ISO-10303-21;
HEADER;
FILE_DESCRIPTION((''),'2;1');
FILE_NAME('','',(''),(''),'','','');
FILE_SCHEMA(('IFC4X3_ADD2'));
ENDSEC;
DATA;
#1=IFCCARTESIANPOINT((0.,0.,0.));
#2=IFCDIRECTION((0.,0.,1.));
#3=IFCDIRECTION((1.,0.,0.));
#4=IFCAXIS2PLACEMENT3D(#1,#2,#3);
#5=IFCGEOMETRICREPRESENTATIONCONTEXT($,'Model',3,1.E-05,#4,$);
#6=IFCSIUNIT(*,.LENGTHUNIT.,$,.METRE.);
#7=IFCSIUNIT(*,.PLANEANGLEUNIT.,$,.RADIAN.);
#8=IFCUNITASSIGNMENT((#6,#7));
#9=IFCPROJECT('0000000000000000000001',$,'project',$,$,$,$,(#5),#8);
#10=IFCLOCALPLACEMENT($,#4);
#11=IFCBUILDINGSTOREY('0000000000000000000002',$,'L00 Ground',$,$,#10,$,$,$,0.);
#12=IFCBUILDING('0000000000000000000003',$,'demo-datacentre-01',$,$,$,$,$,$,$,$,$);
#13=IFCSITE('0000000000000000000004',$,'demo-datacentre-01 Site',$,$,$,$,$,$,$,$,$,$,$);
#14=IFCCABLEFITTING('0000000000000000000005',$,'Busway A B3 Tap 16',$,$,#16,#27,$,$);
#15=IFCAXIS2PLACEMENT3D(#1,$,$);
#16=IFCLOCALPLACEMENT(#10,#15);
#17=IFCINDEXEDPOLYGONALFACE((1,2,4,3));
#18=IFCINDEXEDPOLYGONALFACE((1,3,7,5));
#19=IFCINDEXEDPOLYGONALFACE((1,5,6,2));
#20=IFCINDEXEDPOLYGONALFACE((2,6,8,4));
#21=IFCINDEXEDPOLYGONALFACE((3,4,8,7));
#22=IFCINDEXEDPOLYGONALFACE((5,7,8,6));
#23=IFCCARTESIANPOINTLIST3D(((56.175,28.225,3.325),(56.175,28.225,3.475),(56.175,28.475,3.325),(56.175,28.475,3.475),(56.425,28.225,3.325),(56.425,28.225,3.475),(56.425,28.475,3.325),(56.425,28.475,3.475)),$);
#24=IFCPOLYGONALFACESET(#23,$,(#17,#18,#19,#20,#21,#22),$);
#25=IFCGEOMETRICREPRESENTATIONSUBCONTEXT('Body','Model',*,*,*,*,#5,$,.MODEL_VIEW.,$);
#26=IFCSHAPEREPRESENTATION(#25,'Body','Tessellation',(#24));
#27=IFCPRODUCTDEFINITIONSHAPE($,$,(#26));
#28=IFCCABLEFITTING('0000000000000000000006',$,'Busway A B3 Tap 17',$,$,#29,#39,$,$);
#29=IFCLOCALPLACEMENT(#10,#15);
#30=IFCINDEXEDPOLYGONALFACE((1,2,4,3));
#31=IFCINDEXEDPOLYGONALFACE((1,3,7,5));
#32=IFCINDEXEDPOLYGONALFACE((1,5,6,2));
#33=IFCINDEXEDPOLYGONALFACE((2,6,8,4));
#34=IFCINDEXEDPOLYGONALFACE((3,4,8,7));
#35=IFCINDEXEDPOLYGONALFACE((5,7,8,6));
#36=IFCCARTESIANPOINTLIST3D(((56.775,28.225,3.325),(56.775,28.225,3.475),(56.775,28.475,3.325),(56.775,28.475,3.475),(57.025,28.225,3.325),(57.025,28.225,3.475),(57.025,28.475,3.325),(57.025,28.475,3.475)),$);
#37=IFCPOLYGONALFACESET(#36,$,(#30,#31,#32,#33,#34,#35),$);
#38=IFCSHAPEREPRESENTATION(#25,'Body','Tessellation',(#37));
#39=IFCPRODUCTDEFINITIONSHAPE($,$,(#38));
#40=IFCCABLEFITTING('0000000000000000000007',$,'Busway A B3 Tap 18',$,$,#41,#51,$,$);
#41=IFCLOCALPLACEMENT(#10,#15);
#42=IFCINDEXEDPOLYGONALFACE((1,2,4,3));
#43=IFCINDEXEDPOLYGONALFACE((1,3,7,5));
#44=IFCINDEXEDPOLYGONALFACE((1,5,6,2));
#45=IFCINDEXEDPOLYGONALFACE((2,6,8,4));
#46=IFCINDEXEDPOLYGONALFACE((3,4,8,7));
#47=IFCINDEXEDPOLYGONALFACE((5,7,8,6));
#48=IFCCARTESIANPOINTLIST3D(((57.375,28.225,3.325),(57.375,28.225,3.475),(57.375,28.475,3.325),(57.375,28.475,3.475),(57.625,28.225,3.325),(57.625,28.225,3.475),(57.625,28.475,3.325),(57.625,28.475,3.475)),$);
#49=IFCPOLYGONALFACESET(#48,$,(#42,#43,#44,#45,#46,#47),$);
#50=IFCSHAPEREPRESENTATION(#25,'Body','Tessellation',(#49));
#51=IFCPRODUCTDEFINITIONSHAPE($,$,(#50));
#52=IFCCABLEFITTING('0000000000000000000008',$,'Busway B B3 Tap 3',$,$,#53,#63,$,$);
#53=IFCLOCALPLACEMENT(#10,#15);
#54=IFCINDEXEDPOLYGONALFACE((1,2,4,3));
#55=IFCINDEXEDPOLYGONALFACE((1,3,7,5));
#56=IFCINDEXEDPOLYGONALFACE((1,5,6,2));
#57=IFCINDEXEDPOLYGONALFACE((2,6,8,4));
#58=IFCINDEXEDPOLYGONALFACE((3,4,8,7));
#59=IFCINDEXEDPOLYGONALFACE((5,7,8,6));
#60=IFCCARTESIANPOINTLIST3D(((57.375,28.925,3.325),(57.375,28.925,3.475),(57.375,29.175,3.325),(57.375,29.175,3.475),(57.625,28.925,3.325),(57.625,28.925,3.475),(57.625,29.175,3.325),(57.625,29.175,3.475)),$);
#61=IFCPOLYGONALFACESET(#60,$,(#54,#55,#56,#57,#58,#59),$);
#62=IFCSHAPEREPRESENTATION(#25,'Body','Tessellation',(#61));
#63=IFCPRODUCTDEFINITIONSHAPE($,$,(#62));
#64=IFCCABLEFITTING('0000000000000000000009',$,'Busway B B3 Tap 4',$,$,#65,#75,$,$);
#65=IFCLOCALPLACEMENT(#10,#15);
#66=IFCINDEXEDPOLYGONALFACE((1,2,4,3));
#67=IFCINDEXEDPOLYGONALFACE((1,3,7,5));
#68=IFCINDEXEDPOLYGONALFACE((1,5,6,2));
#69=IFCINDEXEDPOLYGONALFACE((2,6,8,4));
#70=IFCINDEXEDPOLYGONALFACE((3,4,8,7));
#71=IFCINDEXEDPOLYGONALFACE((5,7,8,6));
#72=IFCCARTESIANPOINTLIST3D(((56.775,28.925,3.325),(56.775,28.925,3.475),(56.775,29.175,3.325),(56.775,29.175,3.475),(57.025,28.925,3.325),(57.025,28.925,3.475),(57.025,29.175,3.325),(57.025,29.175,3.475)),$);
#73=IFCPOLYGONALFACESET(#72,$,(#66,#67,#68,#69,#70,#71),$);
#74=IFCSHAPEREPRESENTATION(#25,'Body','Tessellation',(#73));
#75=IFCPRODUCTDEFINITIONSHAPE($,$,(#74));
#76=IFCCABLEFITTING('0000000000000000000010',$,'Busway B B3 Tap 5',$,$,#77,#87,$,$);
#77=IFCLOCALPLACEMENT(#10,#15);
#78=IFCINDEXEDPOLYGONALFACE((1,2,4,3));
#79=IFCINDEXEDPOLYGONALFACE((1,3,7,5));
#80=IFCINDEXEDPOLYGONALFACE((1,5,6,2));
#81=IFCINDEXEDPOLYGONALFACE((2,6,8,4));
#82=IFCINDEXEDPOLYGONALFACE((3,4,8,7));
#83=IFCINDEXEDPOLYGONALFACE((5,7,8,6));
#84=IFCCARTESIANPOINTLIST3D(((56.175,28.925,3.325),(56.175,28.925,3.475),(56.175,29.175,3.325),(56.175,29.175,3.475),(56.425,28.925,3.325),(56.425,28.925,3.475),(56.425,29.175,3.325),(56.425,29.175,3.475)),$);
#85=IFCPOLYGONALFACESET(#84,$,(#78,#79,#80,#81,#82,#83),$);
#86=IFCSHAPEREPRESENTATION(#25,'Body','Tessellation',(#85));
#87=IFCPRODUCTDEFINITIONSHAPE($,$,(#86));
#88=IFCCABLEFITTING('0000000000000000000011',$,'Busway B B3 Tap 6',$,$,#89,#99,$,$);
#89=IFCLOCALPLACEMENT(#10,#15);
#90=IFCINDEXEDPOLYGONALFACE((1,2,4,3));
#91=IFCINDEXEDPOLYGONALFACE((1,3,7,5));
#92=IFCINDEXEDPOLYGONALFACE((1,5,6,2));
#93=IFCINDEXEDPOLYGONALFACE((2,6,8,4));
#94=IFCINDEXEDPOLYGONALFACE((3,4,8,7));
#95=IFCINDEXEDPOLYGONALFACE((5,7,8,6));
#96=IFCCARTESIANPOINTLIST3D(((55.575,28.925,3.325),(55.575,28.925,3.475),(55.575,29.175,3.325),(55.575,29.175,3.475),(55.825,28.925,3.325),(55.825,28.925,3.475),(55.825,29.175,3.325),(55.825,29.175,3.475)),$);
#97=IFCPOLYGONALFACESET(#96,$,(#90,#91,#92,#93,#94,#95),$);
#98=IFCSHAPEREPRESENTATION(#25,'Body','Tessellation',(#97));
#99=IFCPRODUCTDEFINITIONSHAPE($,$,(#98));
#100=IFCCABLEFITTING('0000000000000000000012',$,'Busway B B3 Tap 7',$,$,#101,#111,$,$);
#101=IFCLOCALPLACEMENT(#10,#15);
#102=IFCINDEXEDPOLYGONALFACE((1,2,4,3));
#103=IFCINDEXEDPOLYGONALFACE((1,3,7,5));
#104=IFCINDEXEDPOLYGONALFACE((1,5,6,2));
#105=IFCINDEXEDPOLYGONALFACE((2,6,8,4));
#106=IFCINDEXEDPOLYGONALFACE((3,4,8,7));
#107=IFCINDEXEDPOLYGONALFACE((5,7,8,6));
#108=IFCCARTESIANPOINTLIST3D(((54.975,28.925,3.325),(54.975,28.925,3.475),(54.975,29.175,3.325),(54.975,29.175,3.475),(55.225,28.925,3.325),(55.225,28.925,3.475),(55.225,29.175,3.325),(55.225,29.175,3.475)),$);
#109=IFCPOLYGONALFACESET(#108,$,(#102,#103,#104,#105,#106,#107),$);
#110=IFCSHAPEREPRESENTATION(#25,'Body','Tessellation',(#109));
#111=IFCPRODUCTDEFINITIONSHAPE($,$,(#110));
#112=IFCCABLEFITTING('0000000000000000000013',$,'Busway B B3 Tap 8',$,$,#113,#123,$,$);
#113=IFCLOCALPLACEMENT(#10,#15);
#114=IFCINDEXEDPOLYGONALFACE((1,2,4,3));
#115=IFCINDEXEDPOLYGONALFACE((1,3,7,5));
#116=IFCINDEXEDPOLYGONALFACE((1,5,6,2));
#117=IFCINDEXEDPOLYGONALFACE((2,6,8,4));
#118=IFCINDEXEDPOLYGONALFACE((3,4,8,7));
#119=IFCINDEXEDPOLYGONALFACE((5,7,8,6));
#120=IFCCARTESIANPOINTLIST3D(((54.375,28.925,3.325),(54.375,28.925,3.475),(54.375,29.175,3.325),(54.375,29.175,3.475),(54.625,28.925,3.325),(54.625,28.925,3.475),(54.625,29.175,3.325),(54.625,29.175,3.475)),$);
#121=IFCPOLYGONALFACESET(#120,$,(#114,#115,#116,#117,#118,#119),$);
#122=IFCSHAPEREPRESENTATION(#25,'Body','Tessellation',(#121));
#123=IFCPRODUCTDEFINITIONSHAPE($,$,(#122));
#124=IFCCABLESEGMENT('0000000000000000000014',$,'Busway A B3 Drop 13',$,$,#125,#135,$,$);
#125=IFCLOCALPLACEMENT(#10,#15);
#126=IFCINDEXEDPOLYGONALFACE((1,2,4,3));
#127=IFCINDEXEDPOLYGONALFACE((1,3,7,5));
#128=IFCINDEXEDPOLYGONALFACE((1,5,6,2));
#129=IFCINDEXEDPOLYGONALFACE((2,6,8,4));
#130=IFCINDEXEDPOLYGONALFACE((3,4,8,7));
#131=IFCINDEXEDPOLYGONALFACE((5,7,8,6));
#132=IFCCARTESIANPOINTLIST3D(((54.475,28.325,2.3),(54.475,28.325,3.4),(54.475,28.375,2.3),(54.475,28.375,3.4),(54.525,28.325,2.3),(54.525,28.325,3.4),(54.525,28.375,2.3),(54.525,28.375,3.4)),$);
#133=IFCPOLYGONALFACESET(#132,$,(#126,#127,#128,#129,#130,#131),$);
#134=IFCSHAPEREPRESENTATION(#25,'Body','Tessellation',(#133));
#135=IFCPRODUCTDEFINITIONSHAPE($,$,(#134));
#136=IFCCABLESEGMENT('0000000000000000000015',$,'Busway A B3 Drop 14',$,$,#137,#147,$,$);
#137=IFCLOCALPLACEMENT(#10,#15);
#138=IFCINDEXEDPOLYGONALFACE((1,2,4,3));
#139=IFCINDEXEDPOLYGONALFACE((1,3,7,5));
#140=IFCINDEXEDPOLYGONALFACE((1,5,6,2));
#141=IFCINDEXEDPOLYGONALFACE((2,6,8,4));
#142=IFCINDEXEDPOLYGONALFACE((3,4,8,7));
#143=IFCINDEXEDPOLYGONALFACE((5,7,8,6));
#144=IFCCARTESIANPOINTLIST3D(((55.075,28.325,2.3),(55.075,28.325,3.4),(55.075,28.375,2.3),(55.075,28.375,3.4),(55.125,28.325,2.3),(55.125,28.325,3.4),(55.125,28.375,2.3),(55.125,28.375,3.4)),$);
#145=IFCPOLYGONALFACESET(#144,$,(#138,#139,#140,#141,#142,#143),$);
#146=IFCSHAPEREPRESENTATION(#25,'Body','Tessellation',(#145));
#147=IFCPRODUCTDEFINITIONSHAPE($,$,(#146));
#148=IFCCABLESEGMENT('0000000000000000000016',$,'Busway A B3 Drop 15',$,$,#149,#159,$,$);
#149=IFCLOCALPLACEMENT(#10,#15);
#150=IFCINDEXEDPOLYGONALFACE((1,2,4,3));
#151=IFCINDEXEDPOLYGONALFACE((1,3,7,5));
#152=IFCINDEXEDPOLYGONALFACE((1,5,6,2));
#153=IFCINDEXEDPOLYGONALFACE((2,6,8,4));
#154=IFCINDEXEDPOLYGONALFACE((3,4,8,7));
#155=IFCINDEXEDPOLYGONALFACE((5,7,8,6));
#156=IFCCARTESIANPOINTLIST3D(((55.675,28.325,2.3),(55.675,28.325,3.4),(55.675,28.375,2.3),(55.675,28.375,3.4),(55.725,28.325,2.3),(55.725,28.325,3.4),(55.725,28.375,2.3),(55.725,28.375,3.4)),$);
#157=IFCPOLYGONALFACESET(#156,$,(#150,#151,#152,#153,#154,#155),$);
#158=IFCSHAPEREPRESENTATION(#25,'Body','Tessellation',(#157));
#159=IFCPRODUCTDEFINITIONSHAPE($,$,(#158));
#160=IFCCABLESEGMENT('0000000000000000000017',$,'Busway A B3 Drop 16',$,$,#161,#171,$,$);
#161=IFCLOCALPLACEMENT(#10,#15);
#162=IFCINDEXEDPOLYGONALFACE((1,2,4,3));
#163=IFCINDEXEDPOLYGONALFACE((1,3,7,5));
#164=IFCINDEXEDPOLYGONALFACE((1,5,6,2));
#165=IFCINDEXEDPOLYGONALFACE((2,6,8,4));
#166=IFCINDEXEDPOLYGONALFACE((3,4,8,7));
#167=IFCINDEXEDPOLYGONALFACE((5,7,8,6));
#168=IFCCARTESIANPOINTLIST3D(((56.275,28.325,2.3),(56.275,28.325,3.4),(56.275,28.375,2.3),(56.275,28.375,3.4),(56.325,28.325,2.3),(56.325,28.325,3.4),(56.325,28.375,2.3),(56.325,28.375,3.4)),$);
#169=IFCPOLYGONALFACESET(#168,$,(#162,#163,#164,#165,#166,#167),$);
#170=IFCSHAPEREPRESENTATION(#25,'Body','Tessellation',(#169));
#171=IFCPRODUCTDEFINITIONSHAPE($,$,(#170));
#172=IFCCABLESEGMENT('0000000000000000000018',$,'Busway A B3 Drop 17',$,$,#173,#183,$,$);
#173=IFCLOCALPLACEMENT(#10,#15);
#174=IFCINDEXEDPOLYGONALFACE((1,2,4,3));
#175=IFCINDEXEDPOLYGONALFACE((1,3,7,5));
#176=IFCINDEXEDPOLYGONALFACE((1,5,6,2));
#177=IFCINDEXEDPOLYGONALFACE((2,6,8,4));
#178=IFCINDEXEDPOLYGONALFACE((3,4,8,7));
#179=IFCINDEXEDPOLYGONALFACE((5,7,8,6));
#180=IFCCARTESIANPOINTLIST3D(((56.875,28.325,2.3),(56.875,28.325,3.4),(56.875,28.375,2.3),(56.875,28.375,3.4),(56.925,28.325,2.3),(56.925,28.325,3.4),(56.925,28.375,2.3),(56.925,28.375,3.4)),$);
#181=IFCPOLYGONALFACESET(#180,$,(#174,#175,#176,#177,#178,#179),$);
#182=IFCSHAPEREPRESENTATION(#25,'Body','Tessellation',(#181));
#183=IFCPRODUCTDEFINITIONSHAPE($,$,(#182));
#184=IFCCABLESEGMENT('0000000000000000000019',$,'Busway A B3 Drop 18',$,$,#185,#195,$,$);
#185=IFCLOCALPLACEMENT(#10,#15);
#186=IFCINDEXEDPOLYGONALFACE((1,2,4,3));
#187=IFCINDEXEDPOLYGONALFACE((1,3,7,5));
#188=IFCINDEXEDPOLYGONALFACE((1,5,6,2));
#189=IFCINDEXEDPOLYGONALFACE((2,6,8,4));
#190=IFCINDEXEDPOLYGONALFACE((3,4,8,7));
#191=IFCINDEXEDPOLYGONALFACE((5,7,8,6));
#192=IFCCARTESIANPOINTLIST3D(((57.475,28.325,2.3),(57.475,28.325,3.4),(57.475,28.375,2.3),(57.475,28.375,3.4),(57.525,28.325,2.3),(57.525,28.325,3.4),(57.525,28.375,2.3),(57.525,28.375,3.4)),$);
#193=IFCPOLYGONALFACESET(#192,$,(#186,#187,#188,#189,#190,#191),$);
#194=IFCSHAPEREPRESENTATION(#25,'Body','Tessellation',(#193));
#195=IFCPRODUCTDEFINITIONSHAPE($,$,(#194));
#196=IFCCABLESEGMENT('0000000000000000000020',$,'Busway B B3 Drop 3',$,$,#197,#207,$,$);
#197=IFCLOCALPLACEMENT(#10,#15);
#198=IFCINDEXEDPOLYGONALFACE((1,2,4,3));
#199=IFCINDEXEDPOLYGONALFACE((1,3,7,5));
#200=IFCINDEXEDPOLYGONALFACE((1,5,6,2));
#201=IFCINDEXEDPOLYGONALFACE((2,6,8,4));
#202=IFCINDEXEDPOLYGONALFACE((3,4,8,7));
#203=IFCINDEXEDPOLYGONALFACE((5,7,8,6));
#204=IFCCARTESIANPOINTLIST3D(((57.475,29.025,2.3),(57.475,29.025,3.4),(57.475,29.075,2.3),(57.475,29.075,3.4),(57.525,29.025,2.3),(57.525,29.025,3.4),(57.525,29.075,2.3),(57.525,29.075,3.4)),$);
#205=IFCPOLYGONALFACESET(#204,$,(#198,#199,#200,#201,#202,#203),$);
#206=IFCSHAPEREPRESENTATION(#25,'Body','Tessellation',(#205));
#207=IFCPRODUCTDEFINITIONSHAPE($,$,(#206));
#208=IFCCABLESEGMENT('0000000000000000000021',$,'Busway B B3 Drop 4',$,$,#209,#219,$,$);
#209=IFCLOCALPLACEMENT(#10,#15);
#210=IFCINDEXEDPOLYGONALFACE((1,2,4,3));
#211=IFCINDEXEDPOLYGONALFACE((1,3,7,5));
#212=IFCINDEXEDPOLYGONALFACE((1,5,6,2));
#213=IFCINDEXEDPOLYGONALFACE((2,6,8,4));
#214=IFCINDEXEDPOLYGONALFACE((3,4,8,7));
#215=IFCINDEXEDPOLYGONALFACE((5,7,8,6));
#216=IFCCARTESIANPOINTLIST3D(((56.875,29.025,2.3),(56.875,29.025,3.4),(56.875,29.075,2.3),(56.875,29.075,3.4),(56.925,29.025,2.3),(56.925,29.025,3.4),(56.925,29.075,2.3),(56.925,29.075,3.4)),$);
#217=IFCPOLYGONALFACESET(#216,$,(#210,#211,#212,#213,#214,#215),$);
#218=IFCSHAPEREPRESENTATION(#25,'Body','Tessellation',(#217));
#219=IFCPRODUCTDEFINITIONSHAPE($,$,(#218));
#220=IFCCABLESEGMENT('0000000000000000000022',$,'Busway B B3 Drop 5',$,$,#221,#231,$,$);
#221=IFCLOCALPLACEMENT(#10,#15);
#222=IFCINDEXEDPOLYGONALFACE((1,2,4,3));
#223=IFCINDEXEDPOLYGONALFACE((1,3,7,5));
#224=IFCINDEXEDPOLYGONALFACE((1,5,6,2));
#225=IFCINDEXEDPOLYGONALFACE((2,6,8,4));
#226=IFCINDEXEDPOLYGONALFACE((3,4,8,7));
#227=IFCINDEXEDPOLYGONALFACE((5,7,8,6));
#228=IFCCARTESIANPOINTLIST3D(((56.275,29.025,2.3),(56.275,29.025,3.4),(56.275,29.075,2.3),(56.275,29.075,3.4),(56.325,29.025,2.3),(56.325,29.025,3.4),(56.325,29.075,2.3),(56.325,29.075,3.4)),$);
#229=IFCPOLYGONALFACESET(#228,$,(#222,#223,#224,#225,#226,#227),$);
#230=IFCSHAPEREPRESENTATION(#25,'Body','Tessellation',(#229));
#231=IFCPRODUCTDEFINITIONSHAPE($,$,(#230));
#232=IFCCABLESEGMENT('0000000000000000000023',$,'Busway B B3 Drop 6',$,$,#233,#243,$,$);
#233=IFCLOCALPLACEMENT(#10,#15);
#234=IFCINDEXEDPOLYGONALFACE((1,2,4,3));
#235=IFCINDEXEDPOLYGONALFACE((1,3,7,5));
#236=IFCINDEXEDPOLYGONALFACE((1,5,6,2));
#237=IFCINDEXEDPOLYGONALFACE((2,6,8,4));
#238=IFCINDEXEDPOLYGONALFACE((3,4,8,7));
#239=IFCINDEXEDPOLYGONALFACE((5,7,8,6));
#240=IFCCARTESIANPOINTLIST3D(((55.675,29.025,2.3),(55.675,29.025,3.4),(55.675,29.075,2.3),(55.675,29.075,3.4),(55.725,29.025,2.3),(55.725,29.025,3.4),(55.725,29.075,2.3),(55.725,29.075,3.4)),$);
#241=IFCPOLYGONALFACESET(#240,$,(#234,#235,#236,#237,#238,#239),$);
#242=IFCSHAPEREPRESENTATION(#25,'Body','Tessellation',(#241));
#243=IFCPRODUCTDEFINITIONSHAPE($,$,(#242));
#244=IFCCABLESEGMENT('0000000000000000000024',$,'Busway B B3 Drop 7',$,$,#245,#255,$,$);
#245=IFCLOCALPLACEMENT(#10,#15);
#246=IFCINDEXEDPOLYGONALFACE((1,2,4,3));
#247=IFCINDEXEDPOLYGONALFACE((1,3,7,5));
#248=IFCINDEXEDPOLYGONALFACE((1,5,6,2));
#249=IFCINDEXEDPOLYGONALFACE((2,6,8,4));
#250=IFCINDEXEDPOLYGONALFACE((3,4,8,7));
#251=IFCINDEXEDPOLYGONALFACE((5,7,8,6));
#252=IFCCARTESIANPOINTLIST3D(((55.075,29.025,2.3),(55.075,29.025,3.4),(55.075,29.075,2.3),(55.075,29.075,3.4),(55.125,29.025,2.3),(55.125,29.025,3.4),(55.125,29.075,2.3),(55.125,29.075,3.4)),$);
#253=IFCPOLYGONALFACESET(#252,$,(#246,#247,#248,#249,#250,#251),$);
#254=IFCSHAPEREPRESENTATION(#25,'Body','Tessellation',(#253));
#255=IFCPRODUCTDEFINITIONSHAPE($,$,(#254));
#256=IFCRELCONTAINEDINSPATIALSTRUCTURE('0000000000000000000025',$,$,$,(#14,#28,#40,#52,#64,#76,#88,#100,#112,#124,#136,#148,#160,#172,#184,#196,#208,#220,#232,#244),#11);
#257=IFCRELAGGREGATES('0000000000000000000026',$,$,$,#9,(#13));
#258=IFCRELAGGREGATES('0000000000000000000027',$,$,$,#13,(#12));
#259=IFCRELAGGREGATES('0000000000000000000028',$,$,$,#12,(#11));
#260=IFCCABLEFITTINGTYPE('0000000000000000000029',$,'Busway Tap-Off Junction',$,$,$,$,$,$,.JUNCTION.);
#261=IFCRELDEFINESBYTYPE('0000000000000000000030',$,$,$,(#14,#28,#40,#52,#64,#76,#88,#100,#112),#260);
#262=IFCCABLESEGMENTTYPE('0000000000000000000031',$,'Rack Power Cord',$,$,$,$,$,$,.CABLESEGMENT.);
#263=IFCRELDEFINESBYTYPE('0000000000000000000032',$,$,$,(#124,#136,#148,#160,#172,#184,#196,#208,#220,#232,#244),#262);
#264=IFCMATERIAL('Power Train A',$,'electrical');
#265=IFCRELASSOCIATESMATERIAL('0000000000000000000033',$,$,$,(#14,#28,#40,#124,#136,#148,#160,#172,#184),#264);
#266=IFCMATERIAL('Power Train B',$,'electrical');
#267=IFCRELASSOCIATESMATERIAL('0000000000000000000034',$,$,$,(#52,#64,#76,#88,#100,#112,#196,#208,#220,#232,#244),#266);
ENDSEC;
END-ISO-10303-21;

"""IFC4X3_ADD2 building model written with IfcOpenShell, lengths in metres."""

from ifc_helpers import new_model, si_unit, frame, origin_with_axes, place, context, subcontext, project, spatial, rectangle, extrude, material, type_object, element, save


model = new_model("IFC4X3_ADD2")

# Units and contexts
model_context = context("Model", 3, precision=1e-05, world=origin_with_axes())
body_context = subcontext(model_context, "Body", "Model", "MODEL_VIEW")
ifc_project = project(units=[si_unit("LENGTHUNIT", "METRE"), si_unit("PLANEANGLEUNIT", "RADIAN")], contexts=[model_context])

# Site, building, storey
site = spatial("IfcSite", under=ifc_project, Name="demo-datacentre-01 Site")
building = spatial("IfcBuilding", under=site, Name="demo-datacentre-01")
storey_placement = place(None, origin_with_axes())
storey = spatial("IfcBuildingStorey", under=building, at=storey_placement, Name="L00 Ground", Elevation=0.0)

# Shared definitions
ifc_material_1 = material(Name="Power Train A", Category="electrical")
ifc_material_2 = material(Name="Power Train B", Category="electrical")

# Cable fittings
cable_fitting_type = type_object("IfcCableFittingType", Name="Busway Tap-Off Junction", PredefinedType="JUNCTION")
for number, where, z_axis, x_axis, name in (
    (1, (56.3, 28.35, 3.325), (0.0, 0.0, 1.0), (1.0, 0.0, 0.0), "Busway A B3 Tap 16"),
    (2, (56.9, 28.35, 3.325), (0.0, 0.0, 1.0), (1.0, 0.0, 0.0), "Busway A B3 Tap 17"),
    (3, (57.5, 28.35, 3.325), (0.0, 0.0, 1.0), (1.0, 0.0, 0.0), "Busway A B3 Tap 18"),
):
    element("IfcCableFitting", number, at=place(storey_placement, frame(where, z_axis=z_axis, x_axis=x_axis)), inside=storey, type_object=cable_fitting_type, material=ifc_material_1, Name=name, context=body_context, shape_type="SweptSolid", body=[
        extrude(rectangle(XDim=0.25, YDim=0.25), origin_with_axes(), (0.0, 0.0, 1.0), 0.15),
    ])
for number, where, z_axis, x_axis, name in (
    (4, (57.5, 29.05, 3.325), (0.0, 0.0, 1.0), (1.0, 0.0, 0.0), "Busway B B3 Tap 3"),
    (5, (56.9, 29.05, 3.325), (0.0, 0.0, 1.0), (1.0, 0.0, 0.0), "Busway B B3 Tap 4"),
    (6, (56.3, 29.05, 3.325), (0.0, 0.0, 1.0), (1.0, 0.0, 0.0), "Busway B B3 Tap 5"),
    (7, (55.7, 29.05, 3.325), (0.0, 0.0, 1.0), (1.0, 0.0, 0.0), "Busway B B3 Tap 6"),
    (8, (55.1, 29.05, 3.325), (0.0, 0.0, 1.0), (1.0, 0.0, 0.0), "Busway B B3 Tap 7"),
    (9, (54.5, 29.05, 3.325), (0.0, 0.0, 1.0), (1.0, 0.0, 0.0), "Busway B B3 Tap 8"),
):
    element("IfcCableFitting", number, at=place(storey_placement, frame(where, z_axis=z_axis, x_axis=x_axis)), inside=storey, type_object=cable_fitting_type, material=ifc_material_2, Name=name, context=body_context, shape_type="SweptSolid", body=[
        extrude(rectangle(XDim=0.25, YDim=0.25), origin_with_axes(), (0.0, 0.0, 1.0), 0.15),
    ])

# Cable segments
cable_segment_type_1 = type_object("IfcCableSegmentType", Name="Rack Power Cord", PredefinedType="CABLESEGMENT")
for number, where, z_axis, x_axis, name in (
    (10, (54.5, 28.35, 3.4), (0.0, 0.0, -1.0), (1.0, 0.0, 0.0), "Busway A B3 Drop 13"),
    (11, (55.1, 28.35, 3.4), (0.0, 0.0, -1.0), (1.0, 0.0, 0.0), "Busway A B3 Drop 14"),
    (12, (55.7, 28.35, 3.4), (0.0, 0.0, -1.0), (1.0, 0.0, 0.0), "Busway A B3 Drop 15"),
    (13, (56.3, 28.35, 3.4), (0.0, 0.0, -1.0), (1.0, 0.0, 0.0), "Busway A B3 Drop 16"),
    (14, (56.9, 28.35, 3.4), (0.0, 0.0, -1.0), (1.0, 0.0, 0.0), "Busway A B3 Drop 17"),
    (15, (57.5, 28.35, 3.4), (0.0, 0.0, -1.0), (1.0, 0.0, 0.0), "Busway A B3 Drop 18"),
):
    element("IfcCableSegment", number, at=place(storey_placement, frame(where, z_axis=z_axis, x_axis=x_axis)), inside=storey, type_object=cable_segment_type_1, material=ifc_material_1, Name=name, context=body_context, shape_type="SweptSolid", body=[
        extrude(rectangle(XDim=0.05, YDim=0.05), origin_with_axes(), (0.0, 0.0, 1.0), 1.1),
    ])
for number, where, z_axis, x_axis, name in (
    (16, (57.5, 29.05, 3.4), (0.0, 0.0, -1.0), (1.0, 0.0, 0.0), "Busway B B3 Drop 3"),
    (17, (56.9, 29.05, 3.4), (0.0, 0.0, -1.0), (1.0, 0.0, 0.0), "Busway B B3 Drop 4"),
    (18, (56.3, 29.05, 3.4), (0.0, 0.0, -1.0), (1.0, 0.0, 0.0), "Busway B B3 Drop 5"),
    (19, (55.7, 29.05, 3.4), (0.0, 0.0, -1.0), (1.0, 0.0, 0.0), "Busway B B3 Drop 6"),
    (20, (55.1, 29.05, 3.4), (0.0, 0.0, -1.0), (1.0, 0.0, 0.0), "Busway B B3 Drop 7"),
):
    element("IfcCableSegment", number, at=place(storey_placement, frame(where, z_axis=z_axis, x_axis=x_axis)), inside=storey, type_object=cable_segment_type_1, material=ifc_material_2, Name=name, context=body_context, shape_type="SweptSolid", body=[
        extrude(rectangle(XDim=0.05, YDim=0.05), origin_with_axes(), (0.0, 0.0, 1.0), 1.1),
    ])

save(model, "model.ifc")
